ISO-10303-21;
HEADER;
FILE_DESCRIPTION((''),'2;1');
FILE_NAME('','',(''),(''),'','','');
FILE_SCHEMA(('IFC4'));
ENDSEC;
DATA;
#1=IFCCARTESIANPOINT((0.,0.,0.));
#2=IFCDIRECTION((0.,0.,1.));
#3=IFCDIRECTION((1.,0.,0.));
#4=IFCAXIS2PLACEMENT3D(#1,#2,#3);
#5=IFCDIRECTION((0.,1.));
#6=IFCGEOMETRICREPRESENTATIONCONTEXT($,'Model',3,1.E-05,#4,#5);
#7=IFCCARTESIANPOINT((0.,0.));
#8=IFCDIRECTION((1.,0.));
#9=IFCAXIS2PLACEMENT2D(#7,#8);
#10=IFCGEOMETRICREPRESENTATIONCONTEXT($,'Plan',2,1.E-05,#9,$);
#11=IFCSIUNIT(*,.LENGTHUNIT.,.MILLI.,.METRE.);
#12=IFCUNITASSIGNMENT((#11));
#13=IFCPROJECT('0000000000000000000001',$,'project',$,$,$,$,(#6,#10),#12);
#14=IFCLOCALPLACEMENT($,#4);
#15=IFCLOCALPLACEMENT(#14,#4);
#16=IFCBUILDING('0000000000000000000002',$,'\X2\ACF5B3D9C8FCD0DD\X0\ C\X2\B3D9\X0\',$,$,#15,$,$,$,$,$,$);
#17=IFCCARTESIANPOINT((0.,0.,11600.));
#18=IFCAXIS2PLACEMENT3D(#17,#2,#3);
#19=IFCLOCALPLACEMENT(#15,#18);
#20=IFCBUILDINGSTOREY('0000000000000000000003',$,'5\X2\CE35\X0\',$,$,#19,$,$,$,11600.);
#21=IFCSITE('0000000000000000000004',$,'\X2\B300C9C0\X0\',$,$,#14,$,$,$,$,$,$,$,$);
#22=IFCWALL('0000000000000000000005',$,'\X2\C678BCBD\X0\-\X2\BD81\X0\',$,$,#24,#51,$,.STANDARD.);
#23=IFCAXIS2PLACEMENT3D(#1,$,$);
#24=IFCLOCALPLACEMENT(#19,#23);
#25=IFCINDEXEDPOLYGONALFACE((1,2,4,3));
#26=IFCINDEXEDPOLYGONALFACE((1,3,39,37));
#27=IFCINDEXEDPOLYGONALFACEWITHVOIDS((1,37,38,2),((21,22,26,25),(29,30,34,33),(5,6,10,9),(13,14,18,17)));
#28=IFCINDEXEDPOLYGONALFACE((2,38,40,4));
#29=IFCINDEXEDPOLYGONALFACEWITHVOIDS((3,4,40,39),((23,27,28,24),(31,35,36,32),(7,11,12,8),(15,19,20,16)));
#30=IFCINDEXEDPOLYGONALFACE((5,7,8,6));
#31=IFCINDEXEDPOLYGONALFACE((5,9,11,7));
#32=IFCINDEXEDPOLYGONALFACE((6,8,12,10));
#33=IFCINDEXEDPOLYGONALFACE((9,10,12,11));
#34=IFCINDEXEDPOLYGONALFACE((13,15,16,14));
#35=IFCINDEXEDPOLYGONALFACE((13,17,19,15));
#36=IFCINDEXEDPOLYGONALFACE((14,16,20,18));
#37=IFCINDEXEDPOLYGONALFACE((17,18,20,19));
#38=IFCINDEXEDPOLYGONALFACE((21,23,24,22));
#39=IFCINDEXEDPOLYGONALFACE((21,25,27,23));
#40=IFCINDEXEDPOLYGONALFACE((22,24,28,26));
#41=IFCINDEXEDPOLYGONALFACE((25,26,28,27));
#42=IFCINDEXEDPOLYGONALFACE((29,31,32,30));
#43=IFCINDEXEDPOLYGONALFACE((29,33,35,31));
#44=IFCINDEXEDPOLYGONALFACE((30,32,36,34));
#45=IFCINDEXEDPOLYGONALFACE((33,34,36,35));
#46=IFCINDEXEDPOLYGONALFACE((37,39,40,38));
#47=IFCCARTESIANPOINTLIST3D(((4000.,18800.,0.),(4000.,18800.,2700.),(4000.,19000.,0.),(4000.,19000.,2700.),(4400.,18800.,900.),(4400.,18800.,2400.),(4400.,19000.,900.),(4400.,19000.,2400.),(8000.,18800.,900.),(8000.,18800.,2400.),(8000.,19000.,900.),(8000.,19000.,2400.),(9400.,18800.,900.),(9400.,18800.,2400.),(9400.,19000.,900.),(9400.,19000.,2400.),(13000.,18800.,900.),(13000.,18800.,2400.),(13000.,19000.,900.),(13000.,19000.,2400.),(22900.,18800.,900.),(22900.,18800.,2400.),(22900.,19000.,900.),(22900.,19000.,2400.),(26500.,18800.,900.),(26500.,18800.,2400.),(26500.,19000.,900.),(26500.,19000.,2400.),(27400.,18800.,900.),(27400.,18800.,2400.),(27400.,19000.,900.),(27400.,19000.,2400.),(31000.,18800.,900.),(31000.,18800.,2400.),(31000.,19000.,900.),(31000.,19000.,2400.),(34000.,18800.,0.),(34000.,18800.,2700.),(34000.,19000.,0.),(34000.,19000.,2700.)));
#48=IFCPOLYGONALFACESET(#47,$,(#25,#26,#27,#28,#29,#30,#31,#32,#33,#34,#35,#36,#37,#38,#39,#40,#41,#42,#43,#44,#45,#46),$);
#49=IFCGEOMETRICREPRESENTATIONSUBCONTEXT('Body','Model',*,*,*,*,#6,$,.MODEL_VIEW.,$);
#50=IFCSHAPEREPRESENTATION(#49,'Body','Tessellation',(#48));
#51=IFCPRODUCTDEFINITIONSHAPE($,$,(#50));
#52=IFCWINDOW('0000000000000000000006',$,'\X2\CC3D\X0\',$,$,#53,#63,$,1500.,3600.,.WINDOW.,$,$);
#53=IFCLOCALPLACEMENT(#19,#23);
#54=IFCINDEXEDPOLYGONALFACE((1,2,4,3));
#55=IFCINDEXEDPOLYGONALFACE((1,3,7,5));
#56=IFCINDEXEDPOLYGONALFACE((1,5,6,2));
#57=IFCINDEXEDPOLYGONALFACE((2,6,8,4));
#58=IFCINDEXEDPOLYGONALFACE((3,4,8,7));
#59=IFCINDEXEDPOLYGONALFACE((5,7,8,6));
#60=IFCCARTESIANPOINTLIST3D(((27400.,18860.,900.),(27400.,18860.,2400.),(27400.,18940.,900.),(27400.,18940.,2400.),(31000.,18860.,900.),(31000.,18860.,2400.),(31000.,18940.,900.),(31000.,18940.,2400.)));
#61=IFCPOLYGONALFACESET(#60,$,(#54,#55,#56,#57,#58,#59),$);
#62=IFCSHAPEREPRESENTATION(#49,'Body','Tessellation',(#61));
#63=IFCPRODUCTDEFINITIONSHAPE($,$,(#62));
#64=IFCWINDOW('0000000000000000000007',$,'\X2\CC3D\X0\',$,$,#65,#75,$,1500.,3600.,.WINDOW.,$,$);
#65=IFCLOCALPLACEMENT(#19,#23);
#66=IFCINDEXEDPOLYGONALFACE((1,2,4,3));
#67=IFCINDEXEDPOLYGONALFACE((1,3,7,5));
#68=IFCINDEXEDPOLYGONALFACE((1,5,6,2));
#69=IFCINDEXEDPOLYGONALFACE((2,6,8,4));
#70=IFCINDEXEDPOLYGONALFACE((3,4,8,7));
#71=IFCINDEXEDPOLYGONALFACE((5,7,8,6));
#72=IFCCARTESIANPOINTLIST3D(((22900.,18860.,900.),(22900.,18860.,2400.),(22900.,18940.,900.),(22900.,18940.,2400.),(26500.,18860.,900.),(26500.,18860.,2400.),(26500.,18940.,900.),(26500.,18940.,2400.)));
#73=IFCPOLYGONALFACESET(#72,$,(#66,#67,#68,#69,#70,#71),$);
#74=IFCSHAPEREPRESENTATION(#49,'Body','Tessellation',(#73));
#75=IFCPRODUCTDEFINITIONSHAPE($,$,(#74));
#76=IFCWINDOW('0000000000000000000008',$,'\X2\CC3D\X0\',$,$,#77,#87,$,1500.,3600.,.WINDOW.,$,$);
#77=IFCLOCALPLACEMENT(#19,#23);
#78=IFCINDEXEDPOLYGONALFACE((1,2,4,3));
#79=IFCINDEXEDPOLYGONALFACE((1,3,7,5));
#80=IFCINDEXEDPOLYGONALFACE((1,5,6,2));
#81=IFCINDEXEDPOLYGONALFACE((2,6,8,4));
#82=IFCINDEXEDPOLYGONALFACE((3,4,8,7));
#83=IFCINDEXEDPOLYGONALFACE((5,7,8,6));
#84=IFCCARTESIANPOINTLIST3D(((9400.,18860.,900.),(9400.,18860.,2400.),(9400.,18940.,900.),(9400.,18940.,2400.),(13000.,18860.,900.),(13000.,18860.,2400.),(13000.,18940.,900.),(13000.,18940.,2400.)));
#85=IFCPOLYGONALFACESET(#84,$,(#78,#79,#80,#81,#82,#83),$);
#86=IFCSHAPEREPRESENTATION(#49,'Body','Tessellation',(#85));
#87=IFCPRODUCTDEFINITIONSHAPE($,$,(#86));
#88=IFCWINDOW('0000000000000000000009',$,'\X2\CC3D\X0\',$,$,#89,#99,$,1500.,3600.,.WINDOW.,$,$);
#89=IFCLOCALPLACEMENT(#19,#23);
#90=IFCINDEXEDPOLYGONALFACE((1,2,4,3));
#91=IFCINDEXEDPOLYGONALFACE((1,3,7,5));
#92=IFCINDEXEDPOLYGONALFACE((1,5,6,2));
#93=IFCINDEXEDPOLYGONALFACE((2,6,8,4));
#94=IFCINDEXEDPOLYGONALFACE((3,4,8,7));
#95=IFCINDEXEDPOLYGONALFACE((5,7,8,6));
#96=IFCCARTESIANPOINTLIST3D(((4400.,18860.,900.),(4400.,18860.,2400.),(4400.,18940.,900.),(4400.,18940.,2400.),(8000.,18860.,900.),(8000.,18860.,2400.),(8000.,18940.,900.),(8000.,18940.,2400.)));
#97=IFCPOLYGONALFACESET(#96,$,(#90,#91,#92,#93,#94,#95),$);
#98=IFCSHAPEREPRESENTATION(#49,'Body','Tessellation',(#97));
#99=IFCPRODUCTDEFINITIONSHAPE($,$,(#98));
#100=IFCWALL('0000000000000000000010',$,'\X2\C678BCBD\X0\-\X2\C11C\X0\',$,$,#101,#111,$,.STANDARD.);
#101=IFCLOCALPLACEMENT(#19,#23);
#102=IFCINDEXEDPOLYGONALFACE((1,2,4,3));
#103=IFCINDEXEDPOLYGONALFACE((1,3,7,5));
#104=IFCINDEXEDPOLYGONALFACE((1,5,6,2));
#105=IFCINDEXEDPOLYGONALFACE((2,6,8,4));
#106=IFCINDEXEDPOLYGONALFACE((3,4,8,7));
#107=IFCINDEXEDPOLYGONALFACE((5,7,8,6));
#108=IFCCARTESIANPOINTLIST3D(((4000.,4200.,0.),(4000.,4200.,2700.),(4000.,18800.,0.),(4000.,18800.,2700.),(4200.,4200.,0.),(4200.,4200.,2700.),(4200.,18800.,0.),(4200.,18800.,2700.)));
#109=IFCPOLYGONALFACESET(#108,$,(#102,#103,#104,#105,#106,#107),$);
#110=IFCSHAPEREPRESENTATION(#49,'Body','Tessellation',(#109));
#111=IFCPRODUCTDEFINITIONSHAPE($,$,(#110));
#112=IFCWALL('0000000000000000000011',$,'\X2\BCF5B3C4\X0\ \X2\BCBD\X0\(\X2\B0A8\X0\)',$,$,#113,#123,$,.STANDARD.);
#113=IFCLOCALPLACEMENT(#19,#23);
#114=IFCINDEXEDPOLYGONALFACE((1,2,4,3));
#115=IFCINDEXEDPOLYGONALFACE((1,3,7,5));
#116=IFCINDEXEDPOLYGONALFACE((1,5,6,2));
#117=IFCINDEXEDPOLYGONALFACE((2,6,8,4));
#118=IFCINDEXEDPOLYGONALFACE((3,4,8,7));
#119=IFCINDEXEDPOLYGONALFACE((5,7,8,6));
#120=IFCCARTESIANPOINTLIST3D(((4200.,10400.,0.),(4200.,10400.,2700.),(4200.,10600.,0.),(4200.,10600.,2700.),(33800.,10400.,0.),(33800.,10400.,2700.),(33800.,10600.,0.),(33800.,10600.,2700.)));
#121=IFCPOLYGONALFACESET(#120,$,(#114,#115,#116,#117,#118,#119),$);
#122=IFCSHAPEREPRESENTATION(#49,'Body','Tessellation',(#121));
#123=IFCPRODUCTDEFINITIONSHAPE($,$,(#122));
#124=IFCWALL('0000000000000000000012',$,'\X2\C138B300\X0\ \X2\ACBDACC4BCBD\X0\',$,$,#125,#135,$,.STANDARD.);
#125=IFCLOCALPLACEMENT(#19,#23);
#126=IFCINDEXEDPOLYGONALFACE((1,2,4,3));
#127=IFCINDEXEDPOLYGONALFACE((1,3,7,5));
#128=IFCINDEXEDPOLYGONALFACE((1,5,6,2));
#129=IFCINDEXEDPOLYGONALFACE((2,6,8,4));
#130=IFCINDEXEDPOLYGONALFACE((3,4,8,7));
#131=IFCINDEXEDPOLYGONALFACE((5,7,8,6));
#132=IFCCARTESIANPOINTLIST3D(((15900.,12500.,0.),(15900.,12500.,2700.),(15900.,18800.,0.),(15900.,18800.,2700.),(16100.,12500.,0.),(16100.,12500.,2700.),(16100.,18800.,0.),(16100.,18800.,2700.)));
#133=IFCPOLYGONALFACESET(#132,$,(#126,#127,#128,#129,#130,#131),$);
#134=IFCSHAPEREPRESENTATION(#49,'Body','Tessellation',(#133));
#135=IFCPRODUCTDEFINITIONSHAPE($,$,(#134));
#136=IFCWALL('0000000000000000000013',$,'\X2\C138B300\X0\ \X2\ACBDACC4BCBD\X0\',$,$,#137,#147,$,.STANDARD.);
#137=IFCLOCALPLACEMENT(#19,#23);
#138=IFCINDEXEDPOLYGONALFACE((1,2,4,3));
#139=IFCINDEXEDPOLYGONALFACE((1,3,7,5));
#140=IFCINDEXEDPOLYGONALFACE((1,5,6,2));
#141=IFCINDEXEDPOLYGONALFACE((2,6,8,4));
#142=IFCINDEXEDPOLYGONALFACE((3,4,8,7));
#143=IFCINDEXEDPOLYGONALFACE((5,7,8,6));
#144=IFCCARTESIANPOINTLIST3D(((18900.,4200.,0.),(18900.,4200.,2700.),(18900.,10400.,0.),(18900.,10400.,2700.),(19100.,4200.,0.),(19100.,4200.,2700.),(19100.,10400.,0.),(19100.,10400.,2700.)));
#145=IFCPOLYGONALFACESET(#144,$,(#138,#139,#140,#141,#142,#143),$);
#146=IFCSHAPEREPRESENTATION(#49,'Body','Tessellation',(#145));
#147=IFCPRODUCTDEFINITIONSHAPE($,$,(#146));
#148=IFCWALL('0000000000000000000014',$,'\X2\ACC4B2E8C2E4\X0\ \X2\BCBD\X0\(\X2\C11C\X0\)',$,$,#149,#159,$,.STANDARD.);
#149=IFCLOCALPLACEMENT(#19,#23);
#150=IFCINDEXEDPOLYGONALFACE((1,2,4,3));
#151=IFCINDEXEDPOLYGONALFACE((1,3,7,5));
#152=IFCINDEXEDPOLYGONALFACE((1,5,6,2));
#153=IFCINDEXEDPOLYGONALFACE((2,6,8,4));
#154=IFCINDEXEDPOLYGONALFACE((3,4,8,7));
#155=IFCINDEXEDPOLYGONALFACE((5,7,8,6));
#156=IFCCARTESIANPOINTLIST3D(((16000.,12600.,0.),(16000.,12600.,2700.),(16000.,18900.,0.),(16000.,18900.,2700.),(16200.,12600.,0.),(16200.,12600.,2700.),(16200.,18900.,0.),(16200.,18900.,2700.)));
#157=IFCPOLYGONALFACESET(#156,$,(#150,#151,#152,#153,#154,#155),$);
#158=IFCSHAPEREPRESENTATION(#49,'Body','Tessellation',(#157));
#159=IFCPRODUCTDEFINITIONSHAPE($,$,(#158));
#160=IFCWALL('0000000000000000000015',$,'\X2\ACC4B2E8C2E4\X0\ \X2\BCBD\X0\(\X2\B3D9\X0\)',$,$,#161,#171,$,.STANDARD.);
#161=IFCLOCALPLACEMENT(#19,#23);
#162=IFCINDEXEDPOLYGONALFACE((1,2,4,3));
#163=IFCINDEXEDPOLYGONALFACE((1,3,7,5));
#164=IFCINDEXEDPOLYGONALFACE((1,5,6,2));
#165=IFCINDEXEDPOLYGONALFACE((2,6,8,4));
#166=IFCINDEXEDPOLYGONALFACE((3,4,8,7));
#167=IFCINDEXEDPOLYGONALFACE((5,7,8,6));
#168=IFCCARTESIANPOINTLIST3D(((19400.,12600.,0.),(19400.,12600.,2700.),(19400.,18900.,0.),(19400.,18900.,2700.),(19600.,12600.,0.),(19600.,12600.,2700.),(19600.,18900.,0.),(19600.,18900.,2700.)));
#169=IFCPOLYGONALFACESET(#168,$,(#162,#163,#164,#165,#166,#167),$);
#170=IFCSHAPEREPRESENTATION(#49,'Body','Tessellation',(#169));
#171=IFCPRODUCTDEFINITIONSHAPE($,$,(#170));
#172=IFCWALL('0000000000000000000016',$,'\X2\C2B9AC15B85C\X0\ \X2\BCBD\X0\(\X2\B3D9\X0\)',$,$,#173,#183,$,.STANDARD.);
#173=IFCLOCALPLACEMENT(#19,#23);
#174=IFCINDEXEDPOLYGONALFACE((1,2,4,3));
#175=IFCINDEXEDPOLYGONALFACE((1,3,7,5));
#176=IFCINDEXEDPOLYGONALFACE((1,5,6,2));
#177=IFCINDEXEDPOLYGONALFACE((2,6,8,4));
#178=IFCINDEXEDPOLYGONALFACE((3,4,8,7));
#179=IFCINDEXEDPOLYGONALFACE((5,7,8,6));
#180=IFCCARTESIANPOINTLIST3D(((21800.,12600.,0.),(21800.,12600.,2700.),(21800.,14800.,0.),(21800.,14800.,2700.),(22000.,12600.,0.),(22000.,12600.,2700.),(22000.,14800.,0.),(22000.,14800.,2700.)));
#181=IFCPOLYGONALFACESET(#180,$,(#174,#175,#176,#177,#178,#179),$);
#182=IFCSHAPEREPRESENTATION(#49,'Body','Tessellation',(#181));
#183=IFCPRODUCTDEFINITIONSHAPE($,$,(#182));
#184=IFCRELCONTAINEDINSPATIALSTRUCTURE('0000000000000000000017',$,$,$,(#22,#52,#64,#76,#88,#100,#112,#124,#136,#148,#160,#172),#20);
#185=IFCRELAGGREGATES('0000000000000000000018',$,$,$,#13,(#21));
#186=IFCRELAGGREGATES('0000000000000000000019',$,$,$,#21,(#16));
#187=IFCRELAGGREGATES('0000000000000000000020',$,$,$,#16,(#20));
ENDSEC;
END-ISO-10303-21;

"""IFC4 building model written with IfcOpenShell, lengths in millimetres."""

from ifc_helpers import new_model, si_unit, direction, frame, origin_with_axes, origin_2d_with_axis, place, context, subcontext, project, spatial, polyline, outline, extrude, element, fill, save


model = new_model("IFC4")

# Units and contexts
model_context = context("Model", 3, precision=1e-05, world=origin_with_axes(), true_north=direction((0.0, 1.0)))
plan_context = context("Plan", 2, precision=1e-05, world=origin_2d_with_axis())
body_context = subcontext(model_context, "Body", "Model", "MODEL_VIEW")
ifc_project = project(units=[si_unit("LENGTHUNIT", "METRE", prefix="MILLI")], contexts=[model_context, plan_context])

# Site, building, storey
site_placement = place(None, origin_with_axes())
site = spatial("IfcSite", under=ifc_project, at=site_placement, Name="대지")
building_placement = place(site_placement, origin_with_axes())
building = spatial("IfcBuilding", under=site, at=building_placement, Name="공동주택 C동")
storey_placement = place(building_placement, frame((0.0, 0.0, 11600.0), z_axis=(0.0, 0.0, 1.0), x_axis=(1.0, 0.0, 0.0)))
storey = spatial("IfcBuildingStorey", under=building, at=storey_placement, Name="5층", Elevation=11600.0)

# Wall, openings, windows
wall_1_placement = place(storey_placement, origin_with_axes())
wall_1 = element("IfcWall", 1, at=wall_1_placement, inside=storey, Name="외벽-북", PredefinedType="STANDARD", context=body_context, shape_type="SweptSolid", body=[
    extrude(outline(polyline([(34000.0, 18800.0), (4000.0, 18800.0), (4000.0, 19000.0), (34000.0, 19000.0), (34000.0, 18800.0)])), origin_with_axes(), (0.0, 0.0, 1.0), 2700.0),
])
opening_1_placement = place(storey_placement, origin_with_axes())
opening_1 = element("IfcOpeningElement", 2, at=opening_1_placement, cuts=wall_1, PredefinedType="OPENING", context=body_context, shape_type="SweptSolid", body=[
    extrude(outline(polyline([(31000.0, 19050.0), (27400.0, 19050.0), (27400.0, 18750.0), (31000.0, 18750.0), (31000.0, 19050.0)])), frame((0.0, 0.0, 900.0), z_axis=(0.0, 0.0, 1.0), x_axis=(1.0, 0.0, 0.0)), (0.0, 0.0, 1.0), 1500.0),
])
opening_2_placement = place(storey_placement, origin_with_axes())
opening_2 = element("IfcOpeningElement", 3, at=opening_2_placement, cuts=wall_1, PredefinedType="OPENING", context=body_context, shape_type="SweptSolid", body=[
    extrude(outline(polyline([(26500.0, 19050.0), (22900.0, 19050.0), (22900.0, 18750.0), (26500.0, 18750.0), (26500.0, 19050.0)])), frame((0.0, 0.0, 900.0), z_axis=(0.0, 0.0, 1.0), x_axis=(1.0, 0.0, 0.0)), (0.0, 0.0, 1.0), 1500.0),
])
opening_3_placement = place(storey_placement, origin_with_axes())
opening_3 = element("IfcOpeningElement", 4, at=opening_3_placement, cuts=wall_1, PredefinedType="OPENING", context=body_context, shape_type="SweptSolid", body=[
    extrude(outline(polyline([(13000.0, 19050.0), (9400.0, 19050.0), (9400.0, 18750.0), (13000.0, 18750.0), (13000.0, 19050.0)])), frame((0.0, 0.0, 900.0), z_axis=(0.0, 0.0, 1.0), x_axis=(1.0, 0.0, 0.0)), (0.0, 0.0, 1.0), 1500.0),
])
opening_4_placement = place(storey_placement, origin_with_axes())
opening_4 = element("IfcOpeningElement", 5, at=opening_4_placement, cuts=wall_1, PredefinedType="OPENING", context=body_context, shape_type="SweptSolid", body=[
    extrude(outline(polyline([(8000.0, 19050.0), (4400.0, 19050.0), (4400.0, 18750.0), (8000.0, 18750.0), (8000.0, 19050.0)])), frame((0.0, 0.0, 900.0), z_axis=(0.0, 0.0, 1.0), x_axis=(1.0, 0.0, 0.0)), (0.0, 0.0, 1.0), 1500.0),
])
window_1_placement = place(storey_placement, origin_with_axes())
window_1 = element("IfcWindow", 6, at=window_1_placement, inside=storey, Name="창", OverallHeight=1500.0, OverallWidth=3600.0, PredefinedType="WINDOW", context=body_context, shape_type="SweptSolid", body=[
    extrude(outline(polyline([(31000.0, 18940.0), (27400.0, 18940.0), (27400.0, 18860.0), (31000.0, 18860.0), (31000.0, 18940.0)])), frame((0.0, 0.0, 900.0), z_axis=(0.0, 0.0, 1.0), x_axis=(1.0, 0.0, 0.0)), (0.0, 0.0, 1.0), 1500.0),
])
fill(opening_1, window_1)
window_2_placement = place(storey_placement, origin_with_axes())
window_2 = element("IfcWindow", 7, at=window_2_placement, inside=storey, Name="창", OverallHeight=1500.0, OverallWidth=3600.0, PredefinedType="WINDOW", context=body_context, shape_type="SweptSolid", body=[
    extrude(outline(polyline([(26500.0, 18940.0), (22900.0, 18940.0), (22900.0, 18860.0), (26500.0, 18860.0), (26500.0, 18940.0)])), frame((0.0, 0.0, 900.0), z_axis=(0.0, 0.0, 1.0), x_axis=(1.0, 0.0, 0.0)), (0.0, 0.0, 1.0), 1500.0),
])
fill(opening_2, window_2)
window_3_placement = place(storey_placement, origin_with_axes())
window_3 = element("IfcWindow", 8, at=window_3_placement, inside=storey, Name="창", OverallHeight=1500.0, OverallWidth=3600.0, PredefinedType="WINDOW", context=body_context, shape_type="SweptSolid", body=[
    extrude(outline(polyline([(13000.0, 18940.0), (9400.0, 18940.0), (9400.0, 18860.0), (13000.0, 18860.0), (13000.0, 18940.0)])), frame((0.0, 0.0, 900.0), z_axis=(0.0, 0.0, 1.0), x_axis=(1.0, 0.0, 0.0)), (0.0, 0.0, 1.0), 1500.0),
])
fill(opening_3, window_3)
window_4_placement = place(storey_placement, origin_with_axes())
window_4 = element("IfcWindow", 9, at=window_4_placement, inside=storey, Name="창", OverallHeight=1500.0, OverallWidth=3600.0, PredefinedType="WINDOW", context=body_context, shape_type="SweptSolid", body=[
    extrude(outline(polyline([(8000.0, 18940.0), (4400.0, 18940.0), (4400.0, 18860.0), (8000.0, 18860.0), (8000.0, 18940.0)])), frame((0.0, 0.0, 900.0), z_axis=(0.0, 0.0, 1.0), x_axis=(1.0, 0.0, 0.0)), (0.0, 0.0, 1.0), 1500.0),
])
fill(opening_4, window_4)

# Walls
wall_2_placement = place(storey_placement, origin_with_axes())
element("IfcWall", 10, at=wall_2_placement, inside=storey, Name="외벽-서", PredefinedType="STANDARD", context=body_context, shape_type="SweptSolid", body=[
    extrude(outline(polyline([(4200.0, 18800.0), (4200.0, 4200.0), (4000.0, 4200.0), (4000.0, 18800.0), (4200.0, 18800.0)])), origin_with_axes(), (0.0, 0.0, 1.0), 2700.0),
])
wall_3_placement = place(storey_placement, origin_with_axes())
element("IfcWall", 11, at=wall_3_placement, inside=storey, Name="복도 벽(남)", PredefinedType="STANDARD", context=body_context, shape_type="SweptSolid", body=[
    extrude(outline(polyline([(4200.0, 10600.0), (33800.0, 10600.0), (33800.0, 10400.0), (4200.0, 10400.0), (4200.0, 10600.0)])), origin_with_axes(), (0.0, 0.0, 1.0), 2700.0),
])
wall_4_placement = place(storey_placement, origin_with_axes())
element("IfcWall", 12, at=wall_4_placement, inside=storey, Name="세대 경계벽", PredefinedType="STANDARD", context=body_context, shape_type="SweptSolid", body=[
    extrude(outline(polyline([(15900.0, 12500.0), (15900.0, 18800.0), (16100.0, 18800.0), (16100.0, 12500.0), (15900.0, 12500.0)])), origin_with_axes(), (0.0, 0.0, 1.0), 2700.0),
])
wall_5_placement = place(storey_placement, origin_with_axes())
element("IfcWall", 13, at=wall_5_placement, inside=storey, Name="세대 경계벽", PredefinedType="STANDARD", context=body_context, shape_type="SweptSolid", body=[
    extrude(outline(polyline([(18900.0, 4200.0), (18900.0, 10400.0), (19100.0, 10400.0), (19100.0, 4200.0), (18900.0, 4200.0)])), origin_with_axes(), (0.0, 0.0, 1.0), 2700.0),
])
wall_6_placement = place(storey_placement, origin_with_axes())
element("IfcWall", 14, at=wall_6_placement, inside=storey, Name="계단실 벽(서)", PredefinedType="STANDARD", context=body_context, shape_type="SweptSolid", body=[
    extrude(outline(polyline([(16000.0, 12600.0), (16000.0, 18900.0), (16200.0, 18900.0), (16200.0, 12600.0), (16000.0, 12600.0)])), origin_with_axes(), (0.0, 0.0, 1.0), 2700.0),
])
wall_7_placement = place(storey_placement, origin_with_axes())
element("IfcWall", 15, at=wall_7_placement, inside=storey, Name="계단실 벽(동)", PredefinedType="STANDARD", context=body_context, shape_type="SweptSolid", body=[
    extrude(outline(polyline([(19400.0, 12600.0), (19400.0, 18900.0), (19600.0, 18900.0), (19600.0, 12600.0), (19400.0, 12600.0)])), origin_with_axes(), (0.0, 0.0, 1.0), 2700.0),
])
wall_8_placement = place(storey_placement, origin_with_axes())
element("IfcWall", 16, at=wall_8_placement, inside=storey, Name="승강로 벽(동)", PredefinedType="STANDARD", context=body_context, shape_type="SweptSolid", body=[
    extrude(outline(polyline([(21800.0, 12600.0), (21800.0, 14800.0), (22000.0, 14800.0), (22000.0, 12600.0), (21800.0, 12600.0)])), origin_with_axes(), (0.0, 0.0, 1.0), 2700.0),
])

save(model, "model.ifc")
